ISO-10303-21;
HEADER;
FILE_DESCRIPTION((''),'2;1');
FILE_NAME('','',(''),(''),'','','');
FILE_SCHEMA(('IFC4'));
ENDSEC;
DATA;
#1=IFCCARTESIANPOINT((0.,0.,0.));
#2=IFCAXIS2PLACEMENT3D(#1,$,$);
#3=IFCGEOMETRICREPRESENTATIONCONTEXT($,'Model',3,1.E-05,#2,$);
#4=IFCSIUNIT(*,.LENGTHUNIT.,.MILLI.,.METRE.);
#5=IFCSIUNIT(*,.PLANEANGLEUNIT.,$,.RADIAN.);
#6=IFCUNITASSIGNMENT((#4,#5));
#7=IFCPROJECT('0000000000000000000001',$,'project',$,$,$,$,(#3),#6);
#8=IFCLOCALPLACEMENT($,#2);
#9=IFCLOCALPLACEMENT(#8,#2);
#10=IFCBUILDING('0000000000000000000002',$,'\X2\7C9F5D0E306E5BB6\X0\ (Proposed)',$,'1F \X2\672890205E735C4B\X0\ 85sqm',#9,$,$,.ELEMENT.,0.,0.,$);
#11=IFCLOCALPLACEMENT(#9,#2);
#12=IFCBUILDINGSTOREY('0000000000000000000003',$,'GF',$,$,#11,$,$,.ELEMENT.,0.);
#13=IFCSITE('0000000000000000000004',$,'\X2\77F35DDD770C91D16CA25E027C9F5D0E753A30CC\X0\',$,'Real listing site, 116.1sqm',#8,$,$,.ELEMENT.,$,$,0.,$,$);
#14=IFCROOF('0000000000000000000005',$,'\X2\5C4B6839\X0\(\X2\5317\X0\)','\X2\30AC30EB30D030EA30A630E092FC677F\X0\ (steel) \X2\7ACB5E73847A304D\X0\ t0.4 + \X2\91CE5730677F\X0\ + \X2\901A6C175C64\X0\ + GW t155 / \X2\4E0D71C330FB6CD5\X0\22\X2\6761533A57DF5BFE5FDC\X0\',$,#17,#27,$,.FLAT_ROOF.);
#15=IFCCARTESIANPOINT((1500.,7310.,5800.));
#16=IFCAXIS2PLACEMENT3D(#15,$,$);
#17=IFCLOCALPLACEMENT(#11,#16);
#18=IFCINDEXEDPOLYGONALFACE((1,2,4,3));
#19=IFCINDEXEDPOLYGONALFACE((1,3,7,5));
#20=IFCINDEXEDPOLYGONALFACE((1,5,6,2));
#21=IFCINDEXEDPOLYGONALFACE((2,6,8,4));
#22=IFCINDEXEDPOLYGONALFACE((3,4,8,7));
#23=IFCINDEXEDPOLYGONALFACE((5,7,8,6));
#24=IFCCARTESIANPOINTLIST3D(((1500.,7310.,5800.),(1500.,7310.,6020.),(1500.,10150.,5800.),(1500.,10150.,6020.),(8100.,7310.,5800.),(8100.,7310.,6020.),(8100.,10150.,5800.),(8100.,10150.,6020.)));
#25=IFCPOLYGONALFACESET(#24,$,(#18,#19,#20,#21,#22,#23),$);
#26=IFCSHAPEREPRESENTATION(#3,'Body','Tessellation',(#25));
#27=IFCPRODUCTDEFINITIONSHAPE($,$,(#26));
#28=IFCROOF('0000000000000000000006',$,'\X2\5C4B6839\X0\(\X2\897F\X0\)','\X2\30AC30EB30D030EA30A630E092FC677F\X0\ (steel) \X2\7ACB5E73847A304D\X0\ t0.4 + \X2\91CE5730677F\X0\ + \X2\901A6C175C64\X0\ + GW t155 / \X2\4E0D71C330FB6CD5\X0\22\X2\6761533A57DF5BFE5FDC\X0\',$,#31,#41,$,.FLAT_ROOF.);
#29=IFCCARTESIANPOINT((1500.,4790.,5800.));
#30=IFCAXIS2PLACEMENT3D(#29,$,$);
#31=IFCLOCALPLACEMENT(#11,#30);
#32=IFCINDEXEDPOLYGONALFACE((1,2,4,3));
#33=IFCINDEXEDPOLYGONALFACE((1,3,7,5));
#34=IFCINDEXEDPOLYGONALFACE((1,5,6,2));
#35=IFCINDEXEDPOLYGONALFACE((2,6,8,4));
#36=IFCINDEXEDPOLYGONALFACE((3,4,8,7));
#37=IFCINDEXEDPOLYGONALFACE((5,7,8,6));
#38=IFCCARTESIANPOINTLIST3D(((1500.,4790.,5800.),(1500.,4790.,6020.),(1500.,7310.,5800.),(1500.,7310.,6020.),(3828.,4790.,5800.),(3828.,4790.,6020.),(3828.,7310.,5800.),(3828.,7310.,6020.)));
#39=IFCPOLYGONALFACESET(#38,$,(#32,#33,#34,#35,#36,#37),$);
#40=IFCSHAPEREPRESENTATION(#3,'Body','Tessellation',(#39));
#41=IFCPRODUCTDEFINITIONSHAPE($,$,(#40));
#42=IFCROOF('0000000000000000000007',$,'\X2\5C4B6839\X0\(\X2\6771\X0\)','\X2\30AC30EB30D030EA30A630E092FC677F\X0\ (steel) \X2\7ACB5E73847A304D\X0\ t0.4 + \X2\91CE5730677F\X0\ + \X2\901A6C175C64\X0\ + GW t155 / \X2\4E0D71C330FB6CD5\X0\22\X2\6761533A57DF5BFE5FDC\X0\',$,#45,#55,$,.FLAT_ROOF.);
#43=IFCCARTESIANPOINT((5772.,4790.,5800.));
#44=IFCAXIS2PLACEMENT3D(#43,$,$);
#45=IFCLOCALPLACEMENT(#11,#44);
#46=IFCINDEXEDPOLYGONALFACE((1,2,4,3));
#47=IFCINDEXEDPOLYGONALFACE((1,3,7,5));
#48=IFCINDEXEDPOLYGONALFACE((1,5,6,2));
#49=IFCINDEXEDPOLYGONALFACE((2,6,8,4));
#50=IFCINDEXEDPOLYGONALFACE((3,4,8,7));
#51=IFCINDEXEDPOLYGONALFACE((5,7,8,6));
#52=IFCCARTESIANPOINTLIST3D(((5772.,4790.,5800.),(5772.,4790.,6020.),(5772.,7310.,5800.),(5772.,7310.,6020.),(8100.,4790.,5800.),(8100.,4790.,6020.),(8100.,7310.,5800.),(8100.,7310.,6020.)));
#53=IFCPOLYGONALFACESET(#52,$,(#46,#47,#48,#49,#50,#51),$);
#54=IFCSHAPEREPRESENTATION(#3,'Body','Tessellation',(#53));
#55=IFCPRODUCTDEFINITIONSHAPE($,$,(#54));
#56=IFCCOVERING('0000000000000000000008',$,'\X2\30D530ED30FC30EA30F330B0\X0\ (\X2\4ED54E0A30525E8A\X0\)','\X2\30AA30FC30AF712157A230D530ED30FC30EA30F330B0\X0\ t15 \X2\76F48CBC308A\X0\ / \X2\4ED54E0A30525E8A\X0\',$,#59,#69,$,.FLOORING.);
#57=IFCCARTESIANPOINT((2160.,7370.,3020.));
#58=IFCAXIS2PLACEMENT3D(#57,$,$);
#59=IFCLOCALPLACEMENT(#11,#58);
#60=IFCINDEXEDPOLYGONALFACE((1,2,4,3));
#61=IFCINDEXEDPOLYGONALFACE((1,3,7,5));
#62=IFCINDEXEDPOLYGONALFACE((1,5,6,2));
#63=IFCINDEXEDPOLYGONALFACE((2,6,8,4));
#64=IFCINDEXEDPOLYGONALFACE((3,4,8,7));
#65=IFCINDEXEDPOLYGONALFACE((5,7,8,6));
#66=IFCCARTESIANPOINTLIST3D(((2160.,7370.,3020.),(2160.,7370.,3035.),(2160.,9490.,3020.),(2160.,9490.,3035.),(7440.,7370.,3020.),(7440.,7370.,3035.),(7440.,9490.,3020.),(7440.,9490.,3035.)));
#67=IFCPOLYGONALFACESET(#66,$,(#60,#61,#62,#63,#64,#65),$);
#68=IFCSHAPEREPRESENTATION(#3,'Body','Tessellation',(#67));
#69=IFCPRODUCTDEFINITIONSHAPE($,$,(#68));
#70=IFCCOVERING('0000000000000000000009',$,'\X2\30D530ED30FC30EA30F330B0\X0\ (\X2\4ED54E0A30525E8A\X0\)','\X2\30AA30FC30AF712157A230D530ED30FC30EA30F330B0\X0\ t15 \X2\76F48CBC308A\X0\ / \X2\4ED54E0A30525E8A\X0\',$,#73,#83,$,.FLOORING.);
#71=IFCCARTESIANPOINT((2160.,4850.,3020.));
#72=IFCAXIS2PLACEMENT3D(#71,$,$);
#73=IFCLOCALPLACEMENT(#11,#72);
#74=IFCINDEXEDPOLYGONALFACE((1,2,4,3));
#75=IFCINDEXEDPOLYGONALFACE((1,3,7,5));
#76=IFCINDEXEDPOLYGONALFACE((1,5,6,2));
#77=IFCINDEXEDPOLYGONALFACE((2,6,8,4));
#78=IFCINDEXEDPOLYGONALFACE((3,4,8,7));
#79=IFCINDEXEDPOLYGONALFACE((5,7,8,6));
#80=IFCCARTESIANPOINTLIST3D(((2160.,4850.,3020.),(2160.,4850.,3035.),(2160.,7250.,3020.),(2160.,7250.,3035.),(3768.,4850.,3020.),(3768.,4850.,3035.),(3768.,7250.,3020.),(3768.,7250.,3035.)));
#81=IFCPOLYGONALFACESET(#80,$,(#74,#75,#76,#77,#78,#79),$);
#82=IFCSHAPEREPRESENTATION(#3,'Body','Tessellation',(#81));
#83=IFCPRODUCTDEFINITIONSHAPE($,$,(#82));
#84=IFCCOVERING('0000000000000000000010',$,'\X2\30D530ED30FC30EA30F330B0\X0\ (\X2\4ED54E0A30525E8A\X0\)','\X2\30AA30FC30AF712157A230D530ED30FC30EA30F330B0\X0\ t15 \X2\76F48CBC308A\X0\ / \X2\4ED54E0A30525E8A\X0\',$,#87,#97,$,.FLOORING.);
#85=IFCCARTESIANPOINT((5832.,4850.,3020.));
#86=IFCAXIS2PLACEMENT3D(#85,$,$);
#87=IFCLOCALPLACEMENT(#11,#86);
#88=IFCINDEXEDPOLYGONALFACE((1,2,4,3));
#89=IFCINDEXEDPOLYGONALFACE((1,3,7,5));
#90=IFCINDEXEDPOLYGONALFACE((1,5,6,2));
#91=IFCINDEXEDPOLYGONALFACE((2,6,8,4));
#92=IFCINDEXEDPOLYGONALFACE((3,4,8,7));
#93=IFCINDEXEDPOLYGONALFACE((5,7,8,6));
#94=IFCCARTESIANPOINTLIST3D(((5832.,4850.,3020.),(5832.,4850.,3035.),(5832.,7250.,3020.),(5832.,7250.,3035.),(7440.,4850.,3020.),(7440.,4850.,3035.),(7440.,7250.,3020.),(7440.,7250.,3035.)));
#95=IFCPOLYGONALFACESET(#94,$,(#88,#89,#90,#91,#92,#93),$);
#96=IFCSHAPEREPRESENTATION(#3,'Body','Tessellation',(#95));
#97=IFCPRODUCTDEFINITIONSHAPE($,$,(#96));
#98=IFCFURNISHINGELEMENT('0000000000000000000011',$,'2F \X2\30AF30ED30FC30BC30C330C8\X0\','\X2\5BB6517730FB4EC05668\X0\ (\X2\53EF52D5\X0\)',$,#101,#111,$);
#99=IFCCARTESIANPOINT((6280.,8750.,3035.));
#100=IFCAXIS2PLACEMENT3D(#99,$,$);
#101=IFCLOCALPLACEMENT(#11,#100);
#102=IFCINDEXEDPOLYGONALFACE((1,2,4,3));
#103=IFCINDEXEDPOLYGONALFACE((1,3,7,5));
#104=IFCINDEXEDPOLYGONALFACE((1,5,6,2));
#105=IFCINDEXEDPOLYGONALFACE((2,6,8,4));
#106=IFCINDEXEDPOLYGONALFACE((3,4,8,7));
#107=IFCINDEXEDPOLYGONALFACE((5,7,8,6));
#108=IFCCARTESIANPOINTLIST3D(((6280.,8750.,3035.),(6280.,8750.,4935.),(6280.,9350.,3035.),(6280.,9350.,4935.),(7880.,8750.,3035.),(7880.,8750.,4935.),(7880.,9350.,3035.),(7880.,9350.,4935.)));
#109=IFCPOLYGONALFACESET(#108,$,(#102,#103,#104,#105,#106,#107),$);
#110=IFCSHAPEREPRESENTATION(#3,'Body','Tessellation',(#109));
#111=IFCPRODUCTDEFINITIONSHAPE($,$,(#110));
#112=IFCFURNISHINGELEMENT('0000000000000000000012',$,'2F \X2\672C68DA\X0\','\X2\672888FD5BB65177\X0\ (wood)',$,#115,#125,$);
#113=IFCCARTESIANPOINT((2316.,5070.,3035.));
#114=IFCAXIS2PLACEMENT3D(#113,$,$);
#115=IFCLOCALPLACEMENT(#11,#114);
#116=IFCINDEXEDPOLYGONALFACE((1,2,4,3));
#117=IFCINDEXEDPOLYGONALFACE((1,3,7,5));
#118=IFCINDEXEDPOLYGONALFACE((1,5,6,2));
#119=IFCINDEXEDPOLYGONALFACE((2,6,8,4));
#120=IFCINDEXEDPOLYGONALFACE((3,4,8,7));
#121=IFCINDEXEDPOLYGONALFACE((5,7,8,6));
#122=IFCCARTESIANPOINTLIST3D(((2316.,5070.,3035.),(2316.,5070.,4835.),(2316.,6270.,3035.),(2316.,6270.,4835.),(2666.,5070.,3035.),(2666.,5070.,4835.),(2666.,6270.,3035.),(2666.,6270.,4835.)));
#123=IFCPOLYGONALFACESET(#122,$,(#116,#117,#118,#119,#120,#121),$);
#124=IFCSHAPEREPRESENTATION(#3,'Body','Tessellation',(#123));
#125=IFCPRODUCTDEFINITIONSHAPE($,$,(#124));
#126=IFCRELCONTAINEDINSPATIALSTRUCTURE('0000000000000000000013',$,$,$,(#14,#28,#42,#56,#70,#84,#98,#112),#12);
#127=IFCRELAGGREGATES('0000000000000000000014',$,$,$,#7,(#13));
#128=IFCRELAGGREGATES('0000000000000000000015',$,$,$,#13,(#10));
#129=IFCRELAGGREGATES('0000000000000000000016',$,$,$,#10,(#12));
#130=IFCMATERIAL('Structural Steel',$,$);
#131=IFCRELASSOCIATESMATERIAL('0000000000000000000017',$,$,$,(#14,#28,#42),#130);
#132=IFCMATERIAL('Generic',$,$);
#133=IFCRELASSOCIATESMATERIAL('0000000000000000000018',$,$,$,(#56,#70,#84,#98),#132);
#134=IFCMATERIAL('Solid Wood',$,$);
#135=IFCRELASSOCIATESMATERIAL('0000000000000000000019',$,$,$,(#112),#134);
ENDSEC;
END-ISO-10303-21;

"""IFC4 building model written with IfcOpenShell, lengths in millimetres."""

from ifc_helpers import new_model, si_unit, frame, frame_2d, origin, place, context, project, spatial, rectangle, extrude, material, element, save


model = new_model("IFC4")

# Units and contexts
model_context = context("Model", 3, precision=1e-05, world=origin())
ifc_project = project(units=[si_unit("LENGTHUNIT", "METRE", prefix="MILLI"), si_unit("PLANEANGLEUNIT", "RADIAN")], contexts=[model_context])

# Site, building, storey
site_placement = place(None, origin())
site = spatial("IfcSite", under=ifc_project, at=site_placement, Name="石川県金沢市粟崎町ヌ", ObjectType="Real listing site, 116.1sqm", CompositionType="ELEMENT", RefElevation=0.0)
building_placement = place(site_placement, origin())
building = spatial("IfcBuilding", under=site, at=building_placement, Name="粟崎の家 (Proposed)", ObjectType="1F 木造平屋 85sqm", CompositionType="ELEMENT", ElevationOfRefHeight=0.0, ElevationOfTerrain=0.0)
storey_placement = place(building_placement, origin())
storey = spatial("IfcBuildingStorey", under=building, at=storey_placement, Name="GF", CompositionType="ELEMENT", Elevation=0.0)

# Shared definitions
ifc_material_1 = material(Name="Solid Wood")

# Shared definitions
ifc_material_2 = material(Name="Generic")

# Roofs
ifc_material_3 = material(Name="Structural Steel")
for number, where, name in (
    (1, (1500.0, 7310.0, 5800.0), "屋根(北)"),
):
    element("IfcRoof", number, at=place(storey_placement, frame(where)), inside=storey, material=ifc_material_3, Name=name, Description="ガルバリウム鋼板 (steel) 立平葺き t0.4 + 野地板 + 通気層 + GW t155 / 不燃・法22条区域対応", PredefinedType="FLAT_ROOF", context=model_context, shape_type="SweptSolid", body=[
        extrude(rectangle(XDim=6600.0, YDim=2840.0, at=frame_2d((3300.0, 1420.0))), frame((1500.0, 7310.0, 5800.0)), (0.0, 0.0, 1.0), 220.0),
    ])
roof_1_placement = place(storey_placement, frame((1500.0, 4790.0, 5800.0)))
element("IfcRoof", 2, at=roof_1_placement, inside=storey, material=ifc_material_3, Name="屋根(西)", Description="ガルバリウム鋼板 (steel) 立平葺き t0.4 + 野地板 + 通気層 + GW t155 / 不燃・法22条区域対応", PredefinedType="FLAT_ROOF", context=model_context, shape_type="SweptSolid", body=[
    extrude(rectangle(XDim=2328.0, YDim=2520.0, at=frame_2d((1164.0, 1260.0))), frame((1500.0, 4790.0, 5800.0)), (0.0, 0.0, 1.0), 220.0),
])
roof_2_placement = place(storey_placement, frame((5772.0, 4790.0, 5800.0)))
element("IfcRoof", 3, at=roof_2_placement, inside=storey, material=ifc_material_3, Name="屋根(東)", Description="ガルバリウム鋼板 (steel) 立平葺き t0.4 + 野地板 + 通気層 + GW t155 / 不燃・法22条区域対応", PredefinedType="FLAT_ROOF", context=model_context, shape_type="SweptSolid", body=[
    extrude(rectangle(XDim=2328.0, YDim=2520.0, at=frame_2d((1164.0, 1260.0))), frame((5772.0, 4790.0, 5800.0)), (0.0, 0.0, 1.0), 220.0),
])

# Coverings
covering_1_placement = place(storey_placement, frame((2160.0, 7370.0, 3020.0)))
element("IfcCovering", 4, at=covering_1_placement, inside=storey, material=ifc_material_2, Name="フローリング (仕上げ床)", Description="オーク無垢フローリング t15 直貼り / 仕上げ床", PredefinedType="FLOORING", context=model_context, shape_type="SweptSolid", body=[
    extrude(rectangle(XDim=5280.0, YDim=2120.0, at=frame_2d((2640.0, 1060.0))), frame((2160.0, 7370.0, 3020.0)), (0.0, 0.0, 1.0), 15.0),
])
covering_2_placement = place(storey_placement, frame((2160.0, 4850.0, 3020.0)))
element("IfcCovering", 5, at=covering_2_placement, inside=storey, material=ifc_material_2, Name="フローリング (仕上げ床)", Description="オーク無垢フローリング t15 直貼り / 仕上げ床", PredefinedType="FLOORING", context=model_context, shape_type="SweptSolid", body=[
    extrude(rectangle(XDim=1608.0, YDim=2400.0, at=frame_2d((804.0, 1200.0))), frame((2160.0, 4850.0, 3020.0)), (0.0, 0.0, 1.0), 15.0),
])
covering_3_placement = place(storey_placement, frame((5832.0, 4850.0, 3020.0)))
element("IfcCovering", 6, at=covering_3_placement, inside=storey, material=ifc_material_2, Name="フローリング (仕上げ床)", Description="オーク無垢フローリング t15 直貼り / 仕上げ床", PredefinedType="FLOORING", context=model_context, shape_type="SweptSolid", body=[
    extrude(rectangle(XDim=1608.0, YDim=2400.0, at=frame_2d((804.0, 1200.0))), frame((5832.0, 4850.0, 3020.0)), (0.0, 0.0, 1.0), 15.0),
])

# Furnishing elements
furnishing_1_placement = place(storey_placement, frame((6280.0, 8750.0, 3035.0)))
element("IfcFurnishingElement", 7, at=furnishing_1_placement, inside=storey, material=ifc_material_2, Name="2F クローゼット", Description="家具・什器 (可動)", context=model_context, shape_type="SweptSolid", body=[
    extrude(rectangle(XDim=1600.0, YDim=600.0, at=frame_2d((800.0, 300.0))), frame((6280.0, 8750.0, 3035.0)), (0.0, 0.0, 1.0), 1900.0),
])
furnishing_2_placement = place(storey_placement, frame((2316.0, 5070.0, 3035.0)))
element("IfcFurnishingElement", 8, at=furnishing_2_placement, inside=storey, material=ifc_material_1, Name="2F 本棚", Description="木製家具 (wood)", context=model_context, shape_type="SweptSolid", body=[
    extrude(rectangle(XDim=350.0, YDim=1200.0, at=frame_2d((175.0, 600.0))), frame((2316.0, 5070.0, 3035.0)), (0.0, 0.0, 1.0), 1800.0),
])

save(model, "model.ifc")
